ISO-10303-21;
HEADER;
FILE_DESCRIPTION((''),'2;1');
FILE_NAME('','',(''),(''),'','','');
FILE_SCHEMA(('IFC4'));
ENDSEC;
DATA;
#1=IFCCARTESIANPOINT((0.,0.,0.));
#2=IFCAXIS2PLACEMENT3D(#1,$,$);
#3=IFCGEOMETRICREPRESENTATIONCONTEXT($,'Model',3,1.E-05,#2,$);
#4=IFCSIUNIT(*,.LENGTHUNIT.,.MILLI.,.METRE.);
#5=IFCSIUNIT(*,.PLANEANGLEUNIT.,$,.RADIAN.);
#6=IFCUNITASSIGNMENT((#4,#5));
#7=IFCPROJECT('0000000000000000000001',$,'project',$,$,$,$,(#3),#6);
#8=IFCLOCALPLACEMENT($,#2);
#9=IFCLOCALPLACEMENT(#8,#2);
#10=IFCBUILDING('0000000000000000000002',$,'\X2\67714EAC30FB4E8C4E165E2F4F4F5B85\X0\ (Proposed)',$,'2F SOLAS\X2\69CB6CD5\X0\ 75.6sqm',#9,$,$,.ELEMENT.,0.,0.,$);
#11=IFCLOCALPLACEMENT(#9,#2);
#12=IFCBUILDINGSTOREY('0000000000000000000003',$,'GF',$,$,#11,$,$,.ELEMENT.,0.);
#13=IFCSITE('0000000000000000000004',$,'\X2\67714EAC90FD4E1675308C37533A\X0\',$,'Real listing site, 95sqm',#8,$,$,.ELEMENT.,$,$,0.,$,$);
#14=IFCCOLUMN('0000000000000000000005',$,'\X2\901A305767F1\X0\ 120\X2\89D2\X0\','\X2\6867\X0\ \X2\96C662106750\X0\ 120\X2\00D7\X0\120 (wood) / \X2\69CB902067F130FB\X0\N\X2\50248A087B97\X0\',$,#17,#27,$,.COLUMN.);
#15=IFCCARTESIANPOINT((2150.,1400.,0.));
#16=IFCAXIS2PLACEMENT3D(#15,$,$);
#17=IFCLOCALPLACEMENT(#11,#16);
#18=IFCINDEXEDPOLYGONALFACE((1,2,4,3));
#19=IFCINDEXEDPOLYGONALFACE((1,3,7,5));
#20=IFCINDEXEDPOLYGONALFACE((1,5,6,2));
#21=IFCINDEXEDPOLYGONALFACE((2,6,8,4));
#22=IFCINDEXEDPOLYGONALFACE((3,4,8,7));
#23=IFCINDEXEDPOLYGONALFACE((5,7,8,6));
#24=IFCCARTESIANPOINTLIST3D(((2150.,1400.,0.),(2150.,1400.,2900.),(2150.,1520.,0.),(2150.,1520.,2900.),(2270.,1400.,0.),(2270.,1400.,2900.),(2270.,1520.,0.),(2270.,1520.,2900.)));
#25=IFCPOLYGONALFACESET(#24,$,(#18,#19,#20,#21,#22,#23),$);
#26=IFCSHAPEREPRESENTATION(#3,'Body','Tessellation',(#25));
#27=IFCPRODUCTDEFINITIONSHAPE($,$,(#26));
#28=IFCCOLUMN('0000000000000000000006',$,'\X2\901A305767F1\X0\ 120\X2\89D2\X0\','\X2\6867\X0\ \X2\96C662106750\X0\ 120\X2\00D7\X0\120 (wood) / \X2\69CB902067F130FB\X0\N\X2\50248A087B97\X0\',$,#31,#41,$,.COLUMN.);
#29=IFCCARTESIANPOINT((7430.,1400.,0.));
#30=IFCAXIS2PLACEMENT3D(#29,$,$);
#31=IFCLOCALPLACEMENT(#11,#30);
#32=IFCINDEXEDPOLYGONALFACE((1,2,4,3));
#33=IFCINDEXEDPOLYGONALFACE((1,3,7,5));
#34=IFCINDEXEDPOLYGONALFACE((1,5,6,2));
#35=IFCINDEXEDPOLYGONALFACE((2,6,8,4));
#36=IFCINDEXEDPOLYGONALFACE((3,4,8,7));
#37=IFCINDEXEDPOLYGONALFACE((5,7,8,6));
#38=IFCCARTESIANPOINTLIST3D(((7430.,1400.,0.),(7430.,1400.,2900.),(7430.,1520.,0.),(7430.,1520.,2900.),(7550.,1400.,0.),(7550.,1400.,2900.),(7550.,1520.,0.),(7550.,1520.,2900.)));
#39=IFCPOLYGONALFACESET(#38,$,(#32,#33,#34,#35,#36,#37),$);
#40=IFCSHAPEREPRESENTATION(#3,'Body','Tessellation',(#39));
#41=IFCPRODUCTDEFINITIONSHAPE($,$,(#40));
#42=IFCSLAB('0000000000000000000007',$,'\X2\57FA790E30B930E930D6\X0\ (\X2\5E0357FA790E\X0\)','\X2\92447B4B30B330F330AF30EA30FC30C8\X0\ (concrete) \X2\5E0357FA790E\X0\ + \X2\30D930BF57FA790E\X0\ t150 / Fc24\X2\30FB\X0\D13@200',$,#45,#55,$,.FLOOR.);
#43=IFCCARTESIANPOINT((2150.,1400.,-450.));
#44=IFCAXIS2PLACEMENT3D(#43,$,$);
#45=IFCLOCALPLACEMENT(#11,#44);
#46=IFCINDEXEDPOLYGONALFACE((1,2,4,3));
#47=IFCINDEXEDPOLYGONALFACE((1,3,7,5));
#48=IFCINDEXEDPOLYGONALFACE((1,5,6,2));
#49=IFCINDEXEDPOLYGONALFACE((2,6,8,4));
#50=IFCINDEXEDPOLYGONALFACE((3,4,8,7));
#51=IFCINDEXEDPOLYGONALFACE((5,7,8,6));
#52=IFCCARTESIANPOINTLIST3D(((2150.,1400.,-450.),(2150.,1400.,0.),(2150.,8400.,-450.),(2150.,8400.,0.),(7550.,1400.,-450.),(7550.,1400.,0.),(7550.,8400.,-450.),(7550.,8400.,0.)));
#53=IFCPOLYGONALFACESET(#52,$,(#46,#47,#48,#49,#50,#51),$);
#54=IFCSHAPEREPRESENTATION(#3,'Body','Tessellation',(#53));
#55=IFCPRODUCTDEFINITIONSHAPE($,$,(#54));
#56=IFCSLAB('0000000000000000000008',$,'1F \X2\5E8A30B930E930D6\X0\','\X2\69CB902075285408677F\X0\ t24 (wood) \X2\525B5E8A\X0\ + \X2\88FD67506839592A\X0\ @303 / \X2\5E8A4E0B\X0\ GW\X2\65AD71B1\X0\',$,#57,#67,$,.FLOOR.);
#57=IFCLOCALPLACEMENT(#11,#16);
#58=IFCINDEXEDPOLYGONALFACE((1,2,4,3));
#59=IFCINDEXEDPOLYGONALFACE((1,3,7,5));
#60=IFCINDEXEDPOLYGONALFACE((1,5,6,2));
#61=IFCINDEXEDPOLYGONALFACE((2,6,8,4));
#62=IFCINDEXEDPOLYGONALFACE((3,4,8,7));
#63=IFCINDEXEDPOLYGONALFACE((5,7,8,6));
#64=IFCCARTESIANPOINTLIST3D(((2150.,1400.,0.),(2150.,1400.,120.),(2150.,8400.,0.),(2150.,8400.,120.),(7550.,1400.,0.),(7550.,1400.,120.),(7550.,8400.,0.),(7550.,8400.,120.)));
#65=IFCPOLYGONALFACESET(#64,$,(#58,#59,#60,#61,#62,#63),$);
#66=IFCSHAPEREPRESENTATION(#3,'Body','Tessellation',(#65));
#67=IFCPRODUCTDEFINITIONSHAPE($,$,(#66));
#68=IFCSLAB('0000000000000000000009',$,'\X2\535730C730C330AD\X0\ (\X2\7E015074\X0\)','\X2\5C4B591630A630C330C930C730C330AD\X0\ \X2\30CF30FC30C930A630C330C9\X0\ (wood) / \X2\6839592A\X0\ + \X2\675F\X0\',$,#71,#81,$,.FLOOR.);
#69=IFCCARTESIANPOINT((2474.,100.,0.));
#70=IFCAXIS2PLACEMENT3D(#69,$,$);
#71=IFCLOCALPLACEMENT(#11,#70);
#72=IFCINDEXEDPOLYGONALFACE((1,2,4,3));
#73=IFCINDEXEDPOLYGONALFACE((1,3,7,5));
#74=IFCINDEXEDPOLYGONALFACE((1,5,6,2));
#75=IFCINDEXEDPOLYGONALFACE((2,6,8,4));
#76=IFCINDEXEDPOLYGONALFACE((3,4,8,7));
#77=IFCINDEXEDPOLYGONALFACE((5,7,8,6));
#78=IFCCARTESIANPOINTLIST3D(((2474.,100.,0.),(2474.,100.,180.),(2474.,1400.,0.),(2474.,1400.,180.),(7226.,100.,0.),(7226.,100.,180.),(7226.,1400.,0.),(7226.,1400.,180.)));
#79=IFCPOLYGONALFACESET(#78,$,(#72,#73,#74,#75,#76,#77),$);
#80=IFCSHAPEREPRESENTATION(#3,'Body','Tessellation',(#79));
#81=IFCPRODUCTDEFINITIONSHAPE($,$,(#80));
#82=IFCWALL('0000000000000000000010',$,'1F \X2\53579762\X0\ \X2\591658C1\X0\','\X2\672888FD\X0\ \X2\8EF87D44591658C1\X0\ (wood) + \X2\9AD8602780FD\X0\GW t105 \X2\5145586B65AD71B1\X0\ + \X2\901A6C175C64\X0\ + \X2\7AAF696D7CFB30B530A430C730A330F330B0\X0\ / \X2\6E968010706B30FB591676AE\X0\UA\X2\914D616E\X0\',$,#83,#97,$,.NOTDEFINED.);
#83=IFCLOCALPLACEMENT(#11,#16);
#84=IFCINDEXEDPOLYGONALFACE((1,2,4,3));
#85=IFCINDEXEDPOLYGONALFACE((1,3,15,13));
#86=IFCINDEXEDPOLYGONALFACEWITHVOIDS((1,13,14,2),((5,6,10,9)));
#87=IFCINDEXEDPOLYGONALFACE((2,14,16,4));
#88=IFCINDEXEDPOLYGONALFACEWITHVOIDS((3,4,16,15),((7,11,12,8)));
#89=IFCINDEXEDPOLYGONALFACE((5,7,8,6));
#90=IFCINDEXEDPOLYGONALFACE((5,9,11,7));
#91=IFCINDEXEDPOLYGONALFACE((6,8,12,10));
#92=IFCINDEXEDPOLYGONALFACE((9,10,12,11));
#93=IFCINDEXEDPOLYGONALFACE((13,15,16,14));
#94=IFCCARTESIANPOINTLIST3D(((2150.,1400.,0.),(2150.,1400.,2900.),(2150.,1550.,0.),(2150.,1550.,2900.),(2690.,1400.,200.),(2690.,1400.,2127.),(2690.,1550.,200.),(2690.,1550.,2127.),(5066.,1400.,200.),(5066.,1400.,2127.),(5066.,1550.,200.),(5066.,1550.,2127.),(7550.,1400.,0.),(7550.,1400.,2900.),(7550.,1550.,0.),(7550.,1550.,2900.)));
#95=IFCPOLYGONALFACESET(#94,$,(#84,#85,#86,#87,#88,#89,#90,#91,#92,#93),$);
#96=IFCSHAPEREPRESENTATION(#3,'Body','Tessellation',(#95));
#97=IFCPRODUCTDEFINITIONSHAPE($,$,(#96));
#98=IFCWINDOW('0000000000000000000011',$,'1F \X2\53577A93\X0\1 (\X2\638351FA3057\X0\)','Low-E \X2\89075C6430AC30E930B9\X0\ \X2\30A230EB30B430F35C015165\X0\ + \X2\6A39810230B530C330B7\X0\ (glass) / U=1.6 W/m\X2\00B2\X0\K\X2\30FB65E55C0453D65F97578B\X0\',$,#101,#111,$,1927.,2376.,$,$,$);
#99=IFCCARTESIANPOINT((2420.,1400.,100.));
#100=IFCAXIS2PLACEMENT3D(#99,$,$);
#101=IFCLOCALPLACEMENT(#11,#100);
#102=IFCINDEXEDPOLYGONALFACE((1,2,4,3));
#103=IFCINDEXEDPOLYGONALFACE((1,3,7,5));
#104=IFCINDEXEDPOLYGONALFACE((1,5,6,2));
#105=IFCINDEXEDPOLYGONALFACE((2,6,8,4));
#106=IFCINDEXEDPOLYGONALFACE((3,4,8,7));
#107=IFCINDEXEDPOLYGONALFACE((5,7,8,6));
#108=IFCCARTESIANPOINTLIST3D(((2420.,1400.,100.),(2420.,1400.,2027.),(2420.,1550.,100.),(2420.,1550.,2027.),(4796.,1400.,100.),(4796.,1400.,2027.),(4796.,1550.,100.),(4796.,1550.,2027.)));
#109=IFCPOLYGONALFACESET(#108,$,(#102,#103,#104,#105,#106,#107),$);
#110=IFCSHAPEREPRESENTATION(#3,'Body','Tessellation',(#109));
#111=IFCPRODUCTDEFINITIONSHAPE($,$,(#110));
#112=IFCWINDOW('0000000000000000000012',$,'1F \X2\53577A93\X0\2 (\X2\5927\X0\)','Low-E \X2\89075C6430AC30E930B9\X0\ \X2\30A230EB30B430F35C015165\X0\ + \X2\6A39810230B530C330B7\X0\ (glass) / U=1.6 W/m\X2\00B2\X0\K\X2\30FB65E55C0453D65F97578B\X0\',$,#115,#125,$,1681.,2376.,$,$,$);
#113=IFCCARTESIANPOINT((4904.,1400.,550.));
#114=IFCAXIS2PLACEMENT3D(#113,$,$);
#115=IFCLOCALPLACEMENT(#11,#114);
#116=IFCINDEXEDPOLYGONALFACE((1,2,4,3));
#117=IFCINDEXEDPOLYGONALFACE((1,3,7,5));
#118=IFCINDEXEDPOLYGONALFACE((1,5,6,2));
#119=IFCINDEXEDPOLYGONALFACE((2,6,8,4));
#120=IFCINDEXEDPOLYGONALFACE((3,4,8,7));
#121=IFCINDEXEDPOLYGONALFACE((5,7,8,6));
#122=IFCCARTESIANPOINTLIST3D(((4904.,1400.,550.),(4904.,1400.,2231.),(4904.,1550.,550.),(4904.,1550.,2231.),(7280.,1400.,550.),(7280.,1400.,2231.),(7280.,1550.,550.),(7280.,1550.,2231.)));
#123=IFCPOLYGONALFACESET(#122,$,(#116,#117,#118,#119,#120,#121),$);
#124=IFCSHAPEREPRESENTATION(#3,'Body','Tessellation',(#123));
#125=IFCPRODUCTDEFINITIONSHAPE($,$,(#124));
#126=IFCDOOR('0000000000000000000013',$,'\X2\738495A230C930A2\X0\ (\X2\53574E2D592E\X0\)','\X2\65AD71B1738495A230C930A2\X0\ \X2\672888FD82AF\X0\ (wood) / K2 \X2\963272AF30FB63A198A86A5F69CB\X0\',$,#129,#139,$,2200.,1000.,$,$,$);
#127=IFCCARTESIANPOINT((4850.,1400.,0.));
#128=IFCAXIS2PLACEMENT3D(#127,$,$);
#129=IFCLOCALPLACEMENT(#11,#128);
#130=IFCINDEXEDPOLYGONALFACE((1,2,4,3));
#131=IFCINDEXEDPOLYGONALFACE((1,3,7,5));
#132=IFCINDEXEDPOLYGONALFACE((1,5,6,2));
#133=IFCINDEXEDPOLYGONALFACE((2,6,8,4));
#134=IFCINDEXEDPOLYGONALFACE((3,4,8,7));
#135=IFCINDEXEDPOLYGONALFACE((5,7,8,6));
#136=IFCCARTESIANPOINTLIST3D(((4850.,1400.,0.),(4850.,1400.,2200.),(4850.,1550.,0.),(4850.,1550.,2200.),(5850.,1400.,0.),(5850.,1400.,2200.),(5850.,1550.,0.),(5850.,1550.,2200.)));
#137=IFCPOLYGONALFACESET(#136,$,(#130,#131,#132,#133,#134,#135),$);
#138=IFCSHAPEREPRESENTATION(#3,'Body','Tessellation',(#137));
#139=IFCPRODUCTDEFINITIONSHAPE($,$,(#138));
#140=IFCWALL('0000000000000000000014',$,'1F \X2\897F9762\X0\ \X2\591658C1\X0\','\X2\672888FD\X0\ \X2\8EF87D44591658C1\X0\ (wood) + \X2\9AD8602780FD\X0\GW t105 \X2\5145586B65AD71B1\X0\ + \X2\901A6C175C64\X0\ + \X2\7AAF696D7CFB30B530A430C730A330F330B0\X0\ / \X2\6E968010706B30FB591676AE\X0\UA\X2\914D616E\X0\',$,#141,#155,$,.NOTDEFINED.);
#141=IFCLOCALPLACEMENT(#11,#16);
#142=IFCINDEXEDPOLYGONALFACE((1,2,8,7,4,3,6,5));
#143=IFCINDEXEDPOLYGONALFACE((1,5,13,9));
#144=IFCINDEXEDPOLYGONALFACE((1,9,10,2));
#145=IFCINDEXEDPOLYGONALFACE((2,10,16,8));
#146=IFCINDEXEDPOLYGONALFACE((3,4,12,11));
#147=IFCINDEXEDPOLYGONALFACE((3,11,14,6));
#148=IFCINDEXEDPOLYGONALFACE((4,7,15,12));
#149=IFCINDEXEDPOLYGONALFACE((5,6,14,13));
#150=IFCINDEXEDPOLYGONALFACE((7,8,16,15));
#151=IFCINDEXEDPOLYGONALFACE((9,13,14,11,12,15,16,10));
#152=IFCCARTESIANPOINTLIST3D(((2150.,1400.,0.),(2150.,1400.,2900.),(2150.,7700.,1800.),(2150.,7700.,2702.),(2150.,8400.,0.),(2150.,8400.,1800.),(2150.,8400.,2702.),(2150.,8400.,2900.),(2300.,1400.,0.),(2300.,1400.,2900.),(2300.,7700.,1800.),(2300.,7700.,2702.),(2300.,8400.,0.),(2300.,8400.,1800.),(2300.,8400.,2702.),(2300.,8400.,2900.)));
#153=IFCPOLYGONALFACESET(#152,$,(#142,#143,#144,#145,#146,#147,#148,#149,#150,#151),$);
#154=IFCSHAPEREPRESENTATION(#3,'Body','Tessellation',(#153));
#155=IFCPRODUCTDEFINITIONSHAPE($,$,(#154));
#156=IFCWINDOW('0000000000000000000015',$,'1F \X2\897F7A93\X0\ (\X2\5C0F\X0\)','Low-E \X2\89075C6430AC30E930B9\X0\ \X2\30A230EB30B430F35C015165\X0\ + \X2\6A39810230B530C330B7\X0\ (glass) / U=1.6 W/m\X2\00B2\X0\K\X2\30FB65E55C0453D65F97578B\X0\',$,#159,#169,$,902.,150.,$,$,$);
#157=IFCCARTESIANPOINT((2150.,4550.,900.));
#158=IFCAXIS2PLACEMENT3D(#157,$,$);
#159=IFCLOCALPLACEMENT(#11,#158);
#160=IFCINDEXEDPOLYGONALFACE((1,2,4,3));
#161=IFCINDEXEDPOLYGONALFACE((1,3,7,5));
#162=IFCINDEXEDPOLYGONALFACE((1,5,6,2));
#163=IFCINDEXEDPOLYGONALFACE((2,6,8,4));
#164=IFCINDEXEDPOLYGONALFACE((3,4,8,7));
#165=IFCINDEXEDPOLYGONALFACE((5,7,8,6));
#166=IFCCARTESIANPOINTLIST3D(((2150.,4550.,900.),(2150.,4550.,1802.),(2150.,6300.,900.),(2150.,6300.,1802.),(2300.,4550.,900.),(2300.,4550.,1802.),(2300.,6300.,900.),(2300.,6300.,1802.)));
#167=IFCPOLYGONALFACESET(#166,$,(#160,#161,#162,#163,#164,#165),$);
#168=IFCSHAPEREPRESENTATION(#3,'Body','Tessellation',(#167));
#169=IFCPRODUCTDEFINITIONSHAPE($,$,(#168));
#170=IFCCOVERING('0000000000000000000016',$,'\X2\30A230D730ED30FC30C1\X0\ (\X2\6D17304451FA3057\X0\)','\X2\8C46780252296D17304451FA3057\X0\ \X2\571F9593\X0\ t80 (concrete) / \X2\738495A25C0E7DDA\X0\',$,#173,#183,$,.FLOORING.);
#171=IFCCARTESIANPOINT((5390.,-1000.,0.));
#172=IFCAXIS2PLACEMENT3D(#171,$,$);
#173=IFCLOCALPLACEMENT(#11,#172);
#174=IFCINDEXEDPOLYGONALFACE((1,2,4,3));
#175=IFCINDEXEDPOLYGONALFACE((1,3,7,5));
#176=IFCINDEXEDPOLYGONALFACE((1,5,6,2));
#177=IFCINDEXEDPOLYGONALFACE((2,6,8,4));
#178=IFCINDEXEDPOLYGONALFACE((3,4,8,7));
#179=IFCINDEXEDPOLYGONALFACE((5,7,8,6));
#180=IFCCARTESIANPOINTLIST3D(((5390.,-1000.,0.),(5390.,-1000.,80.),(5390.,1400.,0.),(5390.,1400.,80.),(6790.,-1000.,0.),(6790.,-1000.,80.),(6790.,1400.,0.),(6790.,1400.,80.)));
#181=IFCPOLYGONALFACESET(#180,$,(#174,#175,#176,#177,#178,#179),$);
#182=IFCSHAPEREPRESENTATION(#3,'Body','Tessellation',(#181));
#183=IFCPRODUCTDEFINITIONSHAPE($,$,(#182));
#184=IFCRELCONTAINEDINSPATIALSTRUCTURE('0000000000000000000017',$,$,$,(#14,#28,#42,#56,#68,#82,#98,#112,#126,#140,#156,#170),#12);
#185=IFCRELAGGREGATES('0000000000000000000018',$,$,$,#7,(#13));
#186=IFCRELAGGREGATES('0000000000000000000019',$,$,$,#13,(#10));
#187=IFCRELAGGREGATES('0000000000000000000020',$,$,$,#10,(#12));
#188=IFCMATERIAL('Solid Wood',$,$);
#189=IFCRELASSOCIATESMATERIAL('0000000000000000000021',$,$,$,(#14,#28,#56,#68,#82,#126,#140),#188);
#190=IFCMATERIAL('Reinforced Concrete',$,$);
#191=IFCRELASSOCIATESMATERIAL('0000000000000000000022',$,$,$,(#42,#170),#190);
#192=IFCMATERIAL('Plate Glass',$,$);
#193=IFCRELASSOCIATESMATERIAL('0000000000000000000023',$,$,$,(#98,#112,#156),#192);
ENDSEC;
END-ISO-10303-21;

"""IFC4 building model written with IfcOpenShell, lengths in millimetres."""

from ifc_helpers import new_model, si_unit, frame, frame_2d, origin, place, context, project, spatial, rectangle, extrude, material, element, fill, save


model = new_model("IFC4")

# Units and contexts
model_context = context("Model", 3, precision=1e-05, world=origin())
ifc_project = project(units=[si_unit("LENGTHUNIT", "METRE", prefix="MILLI"), si_unit("PLANEANGLEUNIT", "RADIAN")], contexts=[model_context])

# Site, building, storey
site_placement = place(None, origin())
site = spatial("IfcSite", under=ifc_project, at=site_placement, Name="東京都世田谷区", ObjectType="Real listing site, 95sqm", CompositionType="ELEMENT", RefElevation=0.0)
building_placement = place(site_placement, origin())
building = spatial("IfcBuilding", under=site, at=building_placement, Name="東京・二世帯住宅 (Proposed)", ObjectType="2F SOLAS構法 75.6sqm", CompositionType="ELEMENT", ElevationOfRefHeight=0.0, ElevationOfTerrain=0.0)
storey_placement = place(building_placement, origin())
storey = spatial("IfcBuildingStorey", under=building, at=storey_placement, Name="GF", CompositionType="ELEMENT", Elevation=0.0)

# Columns
ifc_material_1 = material(Name="Solid Wood")
column_1_placement = place(storey_placement, frame((2150.0, 1400.0, 0.0)))
element("IfcColumn", 1, at=column_1_placement, inside=storey, material=ifc_material_1, Name="通し柱 120角", Description="桧 集成材 120×120 (wood) / 構造柱・N値計算", PredefinedType="COLUMN", context=model_context, shape_type="SweptSolid", body=[
    extrude(rectangle(XDim=120.0, YDim=120.0, at=frame_2d((60.0, 60.0))), frame((2150.0, 1400.0, 0.0)), (0.0, 0.0, 1.0), 2900.0),
])
column_2_placement = place(storey_placement, frame((7430.0, 1400.0, 0.0)))
element("IfcColumn", 2, at=column_2_placement, inside=storey, material=ifc_material_1, Name="通し柱 120角", Description="桧 集成材 120×120 (wood) / 構造柱・N値計算", PredefinedType="COLUMN", context=model_context, shape_type="SweptSolid", body=[
    extrude(rectangle(XDim=120.0, YDim=120.0, at=frame_2d((60.0, 60.0))), frame((7430.0, 1400.0, 0.0)), (0.0, 0.0, 1.0), 2900.0),
])

# Slabs
ifc_material_2 = material(Name="Reinforced Concrete")
slab_1_placement = place(storey_placement, frame((2150.0, 1400.0, -450.0)))
element("IfcSlab", 3, at=slab_1_placement, inside=storey, material=ifc_material_2, Name="基礎スラブ (布基礎)", Description="鉄筋コンクリート (concrete) 布基礎 + ベタ基礎 t150 / Fc24・D13@200", PredefinedType="FLOOR", context=model_context, shape_type="SweptSolid", body=[
    extrude(rectangle(XDim=5400.0, YDim=7000.0, at=frame_2d((2700.0, 3500.0))), frame((2150.0, 1400.0, -450.0)), (0.0, 0.0, 1.0), 450.0),
])
slab_2_placement = place(storey_placement, frame((2150.0, 1400.0, 0.0)))
element("IfcSlab", 4, at=slab_2_placement, inside=storey, material=ifc_material_1, Name="1F 床スラブ", Description="構造用合板 t24 (wood) 剛床 + 製材根太 @303 / 床下 GW断熱", PredefinedType="FLOOR", context=model_context, shape_type="SweptSolid", body=[
    extrude(rectangle(XDim=5400.0, YDim=7000.0, at=frame_2d((2700.0, 3500.0))), frame((2150.0, 1400.0, 0.0)), (0.0, 0.0, 1.0), 120.0),
])
slab_3_placement = place(storey_placement, frame((2474.0, 100.0, 0.0)))
element("IfcSlab", 5, at=slab_3_placement, inside=storey, material=ifc_material_1, Name="南デッキ (縁側)", Description="屋外ウッドデッキ ハードウッド (wood) / 根太 + 束", PredefinedType="FLOOR", context=model_context, shape_type="SweptSolid", body=[
    extrude(rectangle(XDim=4752.0, YDim=1300.0, at=frame_2d((2376.0, 650.0))), frame((2474.0, 100.0, 0.0)), (0.0, 0.0, 1.0), 180.0),
])

# Wall, openings, windows, door
wall_1_placement = place(storey_placement, frame((2150.0, 1400.0, 0.0)))
wall_1 = element("IfcWall", 6, at=wall_1_placement, inside=storey, material=ifc_material_1, Name="1F 南面 外壁", Description="木製 軸組外壁 (wood) + 高性能GW t105 充填断熱 + 通気層 + 窯業系サイディング / 準耐火・外皮UA配慮", PredefinedType="NOTDEFINED", context=model_context, shape_type="SweptSolid", body=[
    extrude(rectangle(XDim=5400.0, YDim=150.0, at=frame_2d((2700.0, 75.0))), frame((2150.0, 1400.0, 0.0)), (0.0, 0.0, 1.0), 2900.0),
])
opening_1_placement = place(storey_placement, frame((2420.0, 1400.0, 100.0)))
opening_1 = element("IfcOpeningElement", 7, at=opening_1_placement, cuts=wall_1, PredefinedType="NOTDEFINED", context=model_context, shape_type="SweptSolid", body=[
    extrude(rectangle(XDim=2376.0, YDim=150.0, at=frame_2d((1188.0, 75.0))), frame((2420.0, 1400.0, 100.0)), (0.0, 0.0, 1.0), 1927.0),
])
opening_2_placement = place(storey_placement, frame((4904.0, 1400.0, 550.0)))
opening_2 = element("IfcOpeningElement", 8, at=opening_2_placement, cuts=wall_1, PredefinedType="NOTDEFINED", context=model_context, shape_type="SweptSolid", body=[
    extrude(rectangle(XDim=2376.0, YDim=150.0, at=frame_2d((1188.0, 75.0))), frame((4904.0, 1400.0, 550.0)), (0.0, 0.0, 1.0), 1681.0),
])
opening_3_placement = place(storey_placement, frame((4850.0, 1400.0, 0.0)))
opening_3 = element("IfcOpeningElement", 9, at=opening_3_placement, cuts=wall_1, PredefinedType="NOTDEFINED", context=model_context, shape_type="SweptSolid", body=[
    extrude(rectangle(XDim=1000.0, YDim=150.0, at=frame_2d((500.0, 75.0))), frame((4850.0, 1400.0, 0.0)), (0.0, 0.0, 1.0), 2200.0),
])
ifc_material_3 = material(Name="Plate Glass")
window_1_placement = place(storey_placement, frame((2420.0, 1400.0, 100.0)))
window_1 = element("IfcWindow", 10, at=window_1_placement, inside=storey, material=ifc_material_3, Name="1F 南窓1 (掃出し)", Description="Low-E 複層ガラス アルゴン封入 + 樹脂サッシ (glass) / U=1.6 W/m²K・日射取得型", OverallHeight=1927.0, OverallWidth=2376.0, context=model_context, shape_type="SweptSolid", body=[
    extrude(rectangle(XDim=2376.0, YDim=150.0, at=frame_2d((1188.0, 75.0))), frame((2420.0, 1400.0, 100.0)), (0.0, 0.0, 1.0), 1927.0),
])
fill(opening_1, window_1)
window_2_placement = place(storey_placement, frame((4904.0, 1400.0, 550.0)))
window_2 = element("IfcWindow", 11, at=window_2_placement, inside=storey, material=ifc_material_3, Name="1F 南窓2 (大)", Description="Low-E 複層ガラス アルゴン封入 + 樹脂サッシ (glass) / U=1.6 W/m²K・日射取得型", OverallHeight=1681.0, OverallWidth=2376.0, context=model_context, shape_type="SweptSolid", body=[
    extrude(rectangle(XDim=2376.0, YDim=150.0, at=frame_2d((1188.0, 75.0))), frame((4904.0, 1400.0, 550.0)), (0.0, 0.0, 1.0), 1681.0),
])
fill(opening_2, window_2)
door_placement = place(storey_placement, frame((4850.0, 1400.0, 0.0)))
door = element("IfcDoor", 12, at=door_placement, inside=storey, material=ifc_material_1, Name="玄関ドア (南中央)", Description="断熱玄関ドア 木製芯 (wood) / K2 防犯・採風機構", OverallHeight=2200.0, OverallWidth=1000.0, context=model_context, shape_type="SweptSolid", body=[
    extrude(rectangle(XDim=1000.0, YDim=150.0, at=frame_2d((500.0, 75.0))), frame((4850.0, 1400.0, 0.0)), (0.0, 0.0, 1.0), 2200.0),
])
fill(opening_3, door)

# Wall, opening, window
wall_2_placement = place(storey_placement, frame((2150.0, 1400.0, 0.0)))
wall_2 = element("IfcWall", 13, at=wall_2_placement, inside=storey, material=ifc_material_1, Name="1F 西面 外壁", Description="木製 軸組外壁 (wood) + 高性能GW t105 充填断熱 + 通気層 + 窯業系サイディング / 準耐火・外皮UA配慮", PredefinedType="NOTDEFINED", context=model_context, shape_type="SweptSolid", body=[
    extrude(rectangle(XDim=150.0, YDim=7000.0, at=frame_2d((75.0, 3500.0))), frame((2150.0, 1400.0, 0.0)), (0.0, 0.0, 1.0), 2900.0),
])
opening_4_placement = place(storey_placement, frame((2150.0, 4550.0, 900.0)))
opening_4 = element("IfcOpeningElement", 14, at=opening_4_placement, cuts=wall_2, PredefinedType="NOTDEFINED", context=model_context, shape_type="SweptSolid", body=[
    extrude(rectangle(XDim=150.0, YDim=1750.0, at=frame_2d((75.0, 875.0))), frame((2150.0, 4550.0, 900.0)), (0.0, 0.0, 1.0), 902.0),
])
window_3_placement = place(storey_placement, frame((2150.0, 4550.0, 900.0)))
window_3 = element("IfcWindow", 15, at=window_3_placement, inside=storey, material=ifc_material_3, Name="1F 西窓 (小)", Description="Low-E 複層ガラス アルゴン封入 + 樹脂サッシ (glass) / U=1.6 W/m²K・日射取得型", OverallHeight=902.0, OverallWidth=150.0, context=model_context, shape_type="SweptSolid", body=[
    extrude(rectangle(XDim=150.0, YDim=1750.0, at=frame_2d((75.0, 875.0))), frame((2150.0, 4550.0, 900.0)), (0.0, 0.0, 1.0), 902.0),
])
fill(opening_4, window_3)

# Covering
covering_1_placement = place(storey_placement, frame((5390.0, -1000.0, 0.0)))
element("IfcCovering", 16, at=covering_1_placement, inside=storey, material=ifc_material_2, Name="アプローチ (洗い出し)", Description="豆砂利洗い出し 土間 t80 (concrete) / 玄関導線", PredefinedType="FLOORING", context=model_context, shape_type="SweptSolid", body=[
    extrude(rectangle(XDim=1400.0, YDim=2400.0, at=frame_2d((700.0, 1200.0))), frame((5390.0, -1000.0, 0.0)), (0.0, 0.0, 1.0), 80.0),
])

save(model, "model.ifc")
